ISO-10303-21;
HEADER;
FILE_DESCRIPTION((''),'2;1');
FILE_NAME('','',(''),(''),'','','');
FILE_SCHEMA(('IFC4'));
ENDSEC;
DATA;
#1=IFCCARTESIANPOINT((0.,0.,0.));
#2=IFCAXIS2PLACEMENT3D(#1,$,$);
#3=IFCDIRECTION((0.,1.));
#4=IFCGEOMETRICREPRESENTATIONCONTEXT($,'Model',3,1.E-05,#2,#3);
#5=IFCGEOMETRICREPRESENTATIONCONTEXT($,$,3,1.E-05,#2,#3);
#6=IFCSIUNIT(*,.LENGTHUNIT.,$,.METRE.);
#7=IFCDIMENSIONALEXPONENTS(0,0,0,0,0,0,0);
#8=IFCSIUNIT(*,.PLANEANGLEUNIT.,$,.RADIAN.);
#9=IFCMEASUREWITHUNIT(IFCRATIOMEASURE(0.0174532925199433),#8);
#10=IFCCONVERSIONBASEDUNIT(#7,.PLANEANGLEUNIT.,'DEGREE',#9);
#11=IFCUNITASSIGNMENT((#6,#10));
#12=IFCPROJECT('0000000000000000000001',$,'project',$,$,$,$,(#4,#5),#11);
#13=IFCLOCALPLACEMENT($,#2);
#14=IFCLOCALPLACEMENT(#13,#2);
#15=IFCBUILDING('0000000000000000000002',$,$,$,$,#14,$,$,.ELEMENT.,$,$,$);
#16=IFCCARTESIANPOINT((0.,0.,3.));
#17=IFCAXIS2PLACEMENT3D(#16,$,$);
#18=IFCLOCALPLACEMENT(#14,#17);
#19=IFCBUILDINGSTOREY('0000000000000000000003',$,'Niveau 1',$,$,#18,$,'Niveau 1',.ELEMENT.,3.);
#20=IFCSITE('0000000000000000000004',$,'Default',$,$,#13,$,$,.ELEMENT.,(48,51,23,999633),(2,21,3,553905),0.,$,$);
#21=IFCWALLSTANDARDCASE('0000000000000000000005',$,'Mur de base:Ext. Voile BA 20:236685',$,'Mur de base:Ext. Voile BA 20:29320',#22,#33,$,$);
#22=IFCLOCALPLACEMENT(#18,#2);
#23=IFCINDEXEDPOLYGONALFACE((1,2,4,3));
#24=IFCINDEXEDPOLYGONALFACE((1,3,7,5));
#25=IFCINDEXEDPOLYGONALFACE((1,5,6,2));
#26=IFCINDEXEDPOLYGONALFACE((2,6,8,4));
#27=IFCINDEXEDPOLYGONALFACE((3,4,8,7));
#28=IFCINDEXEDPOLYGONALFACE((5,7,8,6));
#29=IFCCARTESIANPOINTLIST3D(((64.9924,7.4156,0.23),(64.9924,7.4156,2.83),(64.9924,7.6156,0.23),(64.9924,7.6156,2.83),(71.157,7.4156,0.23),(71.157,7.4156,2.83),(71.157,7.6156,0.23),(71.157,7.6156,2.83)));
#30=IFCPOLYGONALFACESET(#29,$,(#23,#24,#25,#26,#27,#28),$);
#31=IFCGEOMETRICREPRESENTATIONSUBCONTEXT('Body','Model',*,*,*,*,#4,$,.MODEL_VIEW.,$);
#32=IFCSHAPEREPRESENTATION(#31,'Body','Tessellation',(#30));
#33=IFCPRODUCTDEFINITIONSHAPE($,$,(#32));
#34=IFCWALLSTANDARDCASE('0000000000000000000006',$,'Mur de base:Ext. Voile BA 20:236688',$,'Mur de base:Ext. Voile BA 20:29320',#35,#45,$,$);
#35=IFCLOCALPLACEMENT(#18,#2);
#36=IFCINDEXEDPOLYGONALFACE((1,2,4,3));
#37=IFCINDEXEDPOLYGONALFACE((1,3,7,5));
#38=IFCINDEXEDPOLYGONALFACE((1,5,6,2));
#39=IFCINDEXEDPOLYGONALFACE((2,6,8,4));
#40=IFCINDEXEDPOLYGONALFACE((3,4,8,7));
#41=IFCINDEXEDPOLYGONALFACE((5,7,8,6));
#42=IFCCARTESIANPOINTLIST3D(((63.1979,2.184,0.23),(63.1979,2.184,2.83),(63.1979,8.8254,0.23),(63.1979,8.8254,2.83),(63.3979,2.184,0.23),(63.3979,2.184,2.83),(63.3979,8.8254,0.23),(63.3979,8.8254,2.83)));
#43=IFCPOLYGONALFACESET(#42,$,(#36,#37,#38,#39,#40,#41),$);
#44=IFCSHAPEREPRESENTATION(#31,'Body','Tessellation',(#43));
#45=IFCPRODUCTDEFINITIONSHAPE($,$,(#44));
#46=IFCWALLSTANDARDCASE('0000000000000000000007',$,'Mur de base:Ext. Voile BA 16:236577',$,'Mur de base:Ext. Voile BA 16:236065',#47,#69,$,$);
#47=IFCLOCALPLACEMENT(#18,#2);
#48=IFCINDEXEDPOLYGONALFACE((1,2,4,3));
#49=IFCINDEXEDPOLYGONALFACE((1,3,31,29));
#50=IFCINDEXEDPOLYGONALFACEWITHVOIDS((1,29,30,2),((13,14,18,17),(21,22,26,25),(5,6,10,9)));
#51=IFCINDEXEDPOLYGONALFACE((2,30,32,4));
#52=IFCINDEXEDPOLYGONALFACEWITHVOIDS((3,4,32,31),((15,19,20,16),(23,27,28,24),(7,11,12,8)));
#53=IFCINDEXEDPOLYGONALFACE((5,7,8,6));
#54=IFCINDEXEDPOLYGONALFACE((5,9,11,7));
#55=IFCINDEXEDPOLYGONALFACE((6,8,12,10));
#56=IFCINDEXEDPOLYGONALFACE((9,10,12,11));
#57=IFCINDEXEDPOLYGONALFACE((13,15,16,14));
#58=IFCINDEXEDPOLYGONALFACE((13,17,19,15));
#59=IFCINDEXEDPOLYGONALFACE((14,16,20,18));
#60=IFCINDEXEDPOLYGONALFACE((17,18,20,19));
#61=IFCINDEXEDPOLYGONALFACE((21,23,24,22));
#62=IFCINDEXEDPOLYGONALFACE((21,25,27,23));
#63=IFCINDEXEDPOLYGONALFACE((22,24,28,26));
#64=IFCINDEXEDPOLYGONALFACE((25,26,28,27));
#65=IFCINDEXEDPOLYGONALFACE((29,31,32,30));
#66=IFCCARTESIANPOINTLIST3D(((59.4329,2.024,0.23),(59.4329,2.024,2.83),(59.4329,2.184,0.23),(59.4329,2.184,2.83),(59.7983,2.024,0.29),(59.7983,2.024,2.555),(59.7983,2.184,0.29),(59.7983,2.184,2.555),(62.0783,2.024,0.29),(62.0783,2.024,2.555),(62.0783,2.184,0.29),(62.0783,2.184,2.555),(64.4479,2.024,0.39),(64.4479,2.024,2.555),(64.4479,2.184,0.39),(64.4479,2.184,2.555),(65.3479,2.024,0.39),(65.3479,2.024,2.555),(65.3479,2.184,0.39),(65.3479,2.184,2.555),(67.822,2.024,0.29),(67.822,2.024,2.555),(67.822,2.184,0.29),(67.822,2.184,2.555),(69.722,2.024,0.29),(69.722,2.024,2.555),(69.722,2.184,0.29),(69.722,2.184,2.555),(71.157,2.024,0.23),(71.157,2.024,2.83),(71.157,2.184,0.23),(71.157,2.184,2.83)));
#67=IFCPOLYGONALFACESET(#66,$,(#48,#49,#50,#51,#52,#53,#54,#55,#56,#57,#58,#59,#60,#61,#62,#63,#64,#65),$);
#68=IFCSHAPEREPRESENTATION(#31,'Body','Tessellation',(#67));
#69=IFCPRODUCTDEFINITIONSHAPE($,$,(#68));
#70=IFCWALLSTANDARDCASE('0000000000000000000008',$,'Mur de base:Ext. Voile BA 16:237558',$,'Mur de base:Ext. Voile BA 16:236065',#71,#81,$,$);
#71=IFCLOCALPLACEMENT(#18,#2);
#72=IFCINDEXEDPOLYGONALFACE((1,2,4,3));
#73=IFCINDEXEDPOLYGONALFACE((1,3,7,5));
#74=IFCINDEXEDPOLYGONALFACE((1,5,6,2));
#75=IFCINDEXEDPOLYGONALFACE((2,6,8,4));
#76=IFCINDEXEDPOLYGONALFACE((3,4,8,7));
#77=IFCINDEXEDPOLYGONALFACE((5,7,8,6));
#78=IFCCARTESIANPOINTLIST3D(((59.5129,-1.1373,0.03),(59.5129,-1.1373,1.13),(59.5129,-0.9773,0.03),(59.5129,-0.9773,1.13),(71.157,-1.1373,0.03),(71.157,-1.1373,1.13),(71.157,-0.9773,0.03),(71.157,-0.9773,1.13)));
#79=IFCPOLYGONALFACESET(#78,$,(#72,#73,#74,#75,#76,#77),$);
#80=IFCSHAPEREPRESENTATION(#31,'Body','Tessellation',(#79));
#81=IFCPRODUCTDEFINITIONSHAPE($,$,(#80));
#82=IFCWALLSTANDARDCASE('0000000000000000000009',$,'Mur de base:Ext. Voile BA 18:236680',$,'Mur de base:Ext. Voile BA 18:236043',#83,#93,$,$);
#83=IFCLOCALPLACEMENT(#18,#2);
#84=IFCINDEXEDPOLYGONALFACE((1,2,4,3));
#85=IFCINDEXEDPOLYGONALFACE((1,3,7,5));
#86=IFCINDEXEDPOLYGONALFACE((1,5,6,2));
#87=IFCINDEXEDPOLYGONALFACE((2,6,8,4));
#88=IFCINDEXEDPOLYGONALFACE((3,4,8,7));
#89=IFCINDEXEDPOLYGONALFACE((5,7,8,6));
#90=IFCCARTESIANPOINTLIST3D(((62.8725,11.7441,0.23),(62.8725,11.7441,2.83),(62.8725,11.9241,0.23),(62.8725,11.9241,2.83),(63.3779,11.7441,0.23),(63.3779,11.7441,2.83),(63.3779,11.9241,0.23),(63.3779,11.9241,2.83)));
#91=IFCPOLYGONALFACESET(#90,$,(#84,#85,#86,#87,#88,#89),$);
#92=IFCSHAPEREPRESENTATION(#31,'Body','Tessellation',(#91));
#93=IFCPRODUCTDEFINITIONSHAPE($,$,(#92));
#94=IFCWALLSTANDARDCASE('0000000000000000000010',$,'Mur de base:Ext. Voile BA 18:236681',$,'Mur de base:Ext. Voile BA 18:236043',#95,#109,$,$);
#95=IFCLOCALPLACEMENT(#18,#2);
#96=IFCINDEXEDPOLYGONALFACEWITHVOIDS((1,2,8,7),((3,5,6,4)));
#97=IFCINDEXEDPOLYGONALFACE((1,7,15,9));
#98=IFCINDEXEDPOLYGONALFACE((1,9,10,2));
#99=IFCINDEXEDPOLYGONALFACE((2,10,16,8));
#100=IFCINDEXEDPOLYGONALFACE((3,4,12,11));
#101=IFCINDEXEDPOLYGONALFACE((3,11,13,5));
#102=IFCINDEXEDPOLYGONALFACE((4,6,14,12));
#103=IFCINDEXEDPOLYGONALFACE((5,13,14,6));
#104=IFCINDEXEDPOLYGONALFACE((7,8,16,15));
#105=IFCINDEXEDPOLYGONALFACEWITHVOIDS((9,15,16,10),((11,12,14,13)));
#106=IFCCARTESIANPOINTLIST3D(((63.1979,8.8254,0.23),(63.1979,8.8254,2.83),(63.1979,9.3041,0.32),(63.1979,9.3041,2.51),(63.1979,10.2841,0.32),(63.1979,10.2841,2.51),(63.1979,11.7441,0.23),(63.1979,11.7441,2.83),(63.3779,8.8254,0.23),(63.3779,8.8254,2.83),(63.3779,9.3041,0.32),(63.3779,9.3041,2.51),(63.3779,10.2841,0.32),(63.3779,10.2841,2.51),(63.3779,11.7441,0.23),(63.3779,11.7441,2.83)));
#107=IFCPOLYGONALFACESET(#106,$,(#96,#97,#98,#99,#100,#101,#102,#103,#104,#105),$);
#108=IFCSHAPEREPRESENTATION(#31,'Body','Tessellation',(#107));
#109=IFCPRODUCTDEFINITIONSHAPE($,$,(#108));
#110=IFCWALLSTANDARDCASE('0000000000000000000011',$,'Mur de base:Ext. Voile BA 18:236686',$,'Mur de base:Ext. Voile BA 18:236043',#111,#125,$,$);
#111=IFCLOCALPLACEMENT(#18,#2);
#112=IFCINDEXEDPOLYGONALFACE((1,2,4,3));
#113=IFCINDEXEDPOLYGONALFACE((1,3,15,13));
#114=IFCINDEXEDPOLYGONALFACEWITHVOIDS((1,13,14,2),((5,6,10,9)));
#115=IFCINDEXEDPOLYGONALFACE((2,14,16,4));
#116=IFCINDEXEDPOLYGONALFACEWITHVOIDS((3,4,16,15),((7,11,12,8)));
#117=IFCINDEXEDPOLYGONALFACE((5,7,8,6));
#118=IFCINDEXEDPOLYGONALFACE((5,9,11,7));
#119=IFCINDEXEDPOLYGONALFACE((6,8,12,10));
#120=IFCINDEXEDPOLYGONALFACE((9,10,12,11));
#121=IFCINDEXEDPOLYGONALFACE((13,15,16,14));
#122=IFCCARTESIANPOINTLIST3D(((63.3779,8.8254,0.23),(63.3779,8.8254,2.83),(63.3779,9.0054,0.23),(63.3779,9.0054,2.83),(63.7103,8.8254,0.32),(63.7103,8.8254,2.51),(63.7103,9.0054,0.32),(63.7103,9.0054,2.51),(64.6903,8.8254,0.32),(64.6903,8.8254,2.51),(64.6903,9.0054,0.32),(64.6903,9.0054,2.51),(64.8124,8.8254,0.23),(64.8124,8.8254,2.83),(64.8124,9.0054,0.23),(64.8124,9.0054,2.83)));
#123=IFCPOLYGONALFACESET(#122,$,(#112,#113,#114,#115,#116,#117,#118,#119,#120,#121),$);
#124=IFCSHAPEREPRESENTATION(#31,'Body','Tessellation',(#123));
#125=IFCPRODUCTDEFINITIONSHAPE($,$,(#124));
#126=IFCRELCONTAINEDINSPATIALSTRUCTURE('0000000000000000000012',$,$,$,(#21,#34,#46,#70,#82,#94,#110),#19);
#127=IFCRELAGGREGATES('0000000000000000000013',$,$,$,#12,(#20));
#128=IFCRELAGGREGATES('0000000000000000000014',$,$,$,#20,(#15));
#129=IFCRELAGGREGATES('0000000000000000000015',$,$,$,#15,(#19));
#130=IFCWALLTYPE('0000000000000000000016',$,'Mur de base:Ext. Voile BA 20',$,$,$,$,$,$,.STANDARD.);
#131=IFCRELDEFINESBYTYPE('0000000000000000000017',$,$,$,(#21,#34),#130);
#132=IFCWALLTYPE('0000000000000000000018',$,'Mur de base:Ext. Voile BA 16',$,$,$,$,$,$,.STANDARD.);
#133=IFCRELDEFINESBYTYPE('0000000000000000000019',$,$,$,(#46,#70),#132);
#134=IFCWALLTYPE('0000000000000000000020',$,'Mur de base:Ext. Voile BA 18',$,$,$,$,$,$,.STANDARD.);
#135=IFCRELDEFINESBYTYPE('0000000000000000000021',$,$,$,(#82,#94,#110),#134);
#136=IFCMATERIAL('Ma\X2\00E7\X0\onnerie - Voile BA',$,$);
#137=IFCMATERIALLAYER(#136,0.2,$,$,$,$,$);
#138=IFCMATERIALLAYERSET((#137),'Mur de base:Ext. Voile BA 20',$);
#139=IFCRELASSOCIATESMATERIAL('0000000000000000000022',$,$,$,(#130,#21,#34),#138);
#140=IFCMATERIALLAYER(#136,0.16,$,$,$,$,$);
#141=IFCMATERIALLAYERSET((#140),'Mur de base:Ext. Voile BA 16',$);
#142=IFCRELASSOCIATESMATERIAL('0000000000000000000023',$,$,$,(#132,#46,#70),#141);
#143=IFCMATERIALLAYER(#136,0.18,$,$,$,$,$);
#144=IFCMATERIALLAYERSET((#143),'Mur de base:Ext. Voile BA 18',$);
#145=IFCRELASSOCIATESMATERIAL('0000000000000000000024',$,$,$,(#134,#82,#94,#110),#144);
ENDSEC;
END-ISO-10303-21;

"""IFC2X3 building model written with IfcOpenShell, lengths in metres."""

from ifc_helpers import new_model, entity, si_unit, converted_unit, direction, frame, frame_2d, origin, origin_2d_with_axis, place, context, subcontext, project, spatial, rectangle, extrude, material, layer, layer_set, layer_usage, type_object, element, save


model = new_model("IFC2X3")

# Units and contexts
model_context = context("Model", 3, precision=1e-05, world=origin(), true_north=direction((0.0, 1.0)))
context_of_model = context(None, 3, precision=1e-05, world=origin(), true_north=direction((0.0, 1.0)))
body_context = subcontext(model_context, "Body", "Model", "MODEL_VIEW")
ifc_project = project(units=[si_unit("LENGTHUNIT", "METRE"), converted_unit("PLANEANGLEUNIT", "DEGREE", entity("IfcRatioMeasure", 0.0174532925199433), si_unit("PLANEANGLEUNIT", "RADIAN"), dimensions=[0, 0, 0, 0, 0, 0, 0])], contexts=[model_context, context_of_model])

# Site, building, storey
site_placement = place(None, origin())
site = spatial("IfcSite", under=ifc_project, at=site_placement, Name="Default", CompositionType="ELEMENT", RefLatitude=(48, 51, 23, 999633), RefLongitude=(2, 21, 3, 553905), RefElevation=0.0)
building_placement = place(site_placement, origin())
building = spatial("IfcBuilding", under=site, at=building_placement, CompositionType="ELEMENT")
storey_placement = place(building_placement, frame((0.0, 0.0, 3.0)))
storey = spatial("IfcBuildingStorey", under=building, at=storey_placement, Name="Niveau 1", LongName="Niveau 1", CompositionType="ELEMENT", Elevation=3.0)

# Walls
ifc_material = material(Name="Maçonnerie - Voile BA")
ifc_layer_1 = layer(ifc_material, 0.2)
ifc_layer_set_1 = layer_set([ifc_layer_1], Name="Mur de base:Ext. Voile BA 20")
ifc_layer_usage_1 = layer_usage(ifc_layer_set_1, "AXIS2", "NEGATIVE", 0.1)
wall_type_1 = type_object("IfcWallType", Name="Mur de base:Ext. Voile BA 20", PredefinedType="STANDARD", material=ifc_layer_set_1)
wall_1_placement = place(storey_placement, frame((64.9924, 7.5156, 0.23)))
element("IfcWallStandardCase", 1, at=wall_1_placement, inside=storey, type_object=wall_type_1, material=ifc_layer_usage_1, Name="Mur de base:Ext. Voile BA 20:236685", ObjectType="Mur de base:Ext. Voile BA 20:29320", context=body_context, shape_type="SweptSolid", body=[
    extrude(rectangle(XDim=6.1647, YDim=0.2, at=frame_2d((3.0823, 0.0), x_axis=(-1.0, 0.0))), origin(), (0.0, 0.0, 1.0), 2.6),
])
ifc_layer_usage_2 = layer_usage(ifc_layer_set_1, "AXIS2", "NEGATIVE", 0.1)
wall_2_placement = place(storey_placement, frame((63.2979, 8.8254, 0.23), z_axis=(0.0, 0.0, 1.0), x_axis=(0.0, -1.0, 0.0)))
element("IfcWallStandardCase", 2, at=wall_2_placement, inside=storey, type_object=wall_type_1, material=ifc_layer_usage_2, Name="Mur de base:Ext. Voile BA 20:236688", ObjectType="Mur de base:Ext. Voile BA 20:29320", context=body_context, shape_type="SweptSolid", body=[
    extrude(rectangle(XDim=6.6414, YDim=0.2, at=frame_2d((3.3207, 0.0), x_axis=(-1.0, 0.0))), origin(), (0.0, 0.0, 1.0), 2.6),
])

# Shared definitions
ifc_layer_2 = layer(ifc_material, 0.16)
ifc_layer_set_2 = layer_set([ifc_layer_2], Name="Mur de base:Ext. Voile BA 16")
wall_type_2 = type_object("IfcWallType", Name="Mur de base:Ext. Voile BA 16", PredefinedType="STANDARD", material=ifc_layer_set_2)

# Wall, openings
ifc_layer_usage_3 = layer_usage(ifc_layer_set_2, "AXIS2", "NEGATIVE", 0.08)
wall_3_placement = place(storey_placement, frame((71.157, 2.104, 0.23), z_axis=(0.0, 0.0, 1.0), x_axis=(-1.0, 0.0, 0.0)))
wall_3 = element("IfcWallStandardCase", 3, at=wall_3_placement, inside=storey, type_object=wall_type_2, material=ifc_layer_usage_3, Name="Mur de base:Ext. Voile BA 16:236577", ObjectType="Mur de base:Ext. Voile BA 16:236065", context=body_context, shape_type="SweptSolid", body=[
    extrude(rectangle(XDim=11.7241, YDim=0.16, at=frame_2d((5.8621, 0.0), x_axis=(-1.0, 0.0))), origin(), (0.0, 0.0, 1.0), 2.6),
])
opening_1_placement = place(wall_3_placement, origin())
element("IfcOpeningElement", 4, at=opening_1_placement, cuts=wall_3, ObjectType="Opening", context=body_context, shape_type="SweptSolid", body=[
    extrude(rectangle(XDim=2.265, YDim=2.28, at=origin_2d_with_axis()), frame((10.2187, -0.08, 1.1925), z_axis=(0.0, 1.0, 0.0), x_axis=(0.0, 0.0, -1.0)), (0.0, 0.0, 1.0), 0.16),
])
opening_2_placement = place(wall_3_placement, origin())
element("IfcOpeningElement", 5, at=opening_2_placement, cuts=wall_3, ObjectType="Opening", context=body_context, shape_type="SweptSolid", body=[
    extrude(rectangle(XDim=2.265, YDim=1.9, at=origin_2d_with_axis()), frame((2.385, -0.08, 1.1925), z_axis=(0.0, 1.0, 0.0), x_axis=(0.0, 0.0, -1.0)), (0.0, 0.0, 1.0), 0.16),
])
opening_3_placement = place(wall_3_placement, origin())
element("IfcOpeningElement", 6, at=opening_3_placement, cuts=wall_3, ObjectType="Opening", context=body_context, shape_type="SweptSolid", body=[
    extrude(rectangle(XDim=2.165, YDim=0.9, at=frame_2d((0.0, 0.0), x_axis=(1.0, 0.0))), frame((6.2591, -0.08, 1.2425), z_axis=(0.0, 1.0, 0.0), x_axis=(0.0, 0.0, -1.0)), (0.0, 0.0, 1.0), 0.16),
])

# Walls
ifc_layer_usage_4 = layer_usage(ifc_layer_set_2, "AXIS2", "POSITIVE", -0.08)
wall_4_placement = place(storey_placement, frame((71.157, -1.0573, 0.03), z_axis=(0.0, 0.0, 1.0), x_axis=(-1.0, 0.0, 0.0)))
element("IfcWallStandardCase", 7, at=wall_4_placement, inside=storey, type_object=wall_type_2, material=ifc_layer_usage_4, Name="Mur de base:Ext. Voile BA 16:237558", ObjectType="Mur de base:Ext. Voile BA 16:236065", context=body_context, shape_type="SweptSolid", body=[
    extrude(rectangle(XDim=11.6441, YDim=0.16, at=frame_2d((5.8221, 0.0), x_axis=(-1.0, 0.0))), origin(), (0.0, 0.0, 1.0), 1.1),
])
ifc_layer_3 = layer(ifc_material, 0.18)
ifc_layer_set_3 = layer_set([ifc_layer_3], Name="Mur de base:Ext. Voile BA 18")
ifc_layer_usage_5 = layer_usage(ifc_layer_set_3, "AXIS2", "NEGATIVE", 0.09)
wall_type_3 = type_object("IfcWallType", Name="Mur de base:Ext. Voile BA 18", PredefinedType="STANDARD", material=ifc_layer_set_3)
wall_5_placement = place(storey_placement, frame((62.8725, 11.8341, 0.23)))
element("IfcWallStandardCase", 8, at=wall_5_placement, inside=storey, type_object=wall_type_3, material=ifc_layer_usage_5, Name="Mur de base:Ext. Voile BA 18:236680", ObjectType="Mur de base:Ext. Voile BA 18:236043", context=body_context, shape_type="SweptSolid", body=[
    extrude(rectangle(XDim=0.5054, YDim=0.18, at=frame_2d((0.2527, 0.0), x_axis=(-1.0, 0.0))), origin(), (0.0, 0.0, 1.0), 2.6),
])

# Walls, openings
ifc_layer_usage_6 = layer_usage(ifc_layer_set_3, "AXIS2", "NEGATIVE", 0.09)
wall_6_placement = place(storey_placement, frame((63.2879, 11.7441, 0.23), z_axis=(0.0, 0.0, 1.0), x_axis=(0.0, -1.0, 0.0)))
wall_6 = element("IfcWallStandardCase", 9, at=wall_6_placement, inside=storey, type_object=wall_type_3, material=ifc_layer_usage_6, Name="Mur de base:Ext. Voile BA 18:236681", ObjectType="Mur de base:Ext. Voile BA 18:236043", context=body_context, shape_type="SweptSolid", body=[
    extrude(rectangle(XDim=2.9187, YDim=0.18, at=frame_2d((1.4593, 0.0), x_axis=(-1.0, 0.0))), origin(), (0.0, 0.0, 1.0), 2.6),
])
opening_4_placement = place(wall_6_placement, origin())
element("IfcOpeningElement", 10, at=opening_4_placement, cuts=wall_6, ObjectType="Opening", context=body_context, shape_type="SweptSolid", body=[
    extrude(rectangle(XDim=2.19, YDim=0.98, at=frame_2d((0.0, 0.0), x_axis=(1.0, 0.0))), frame((1.95, -0.09, 1.185), z_axis=(0.0, 1.0, 0.0), x_axis=(0.0, 0.0, -1.0)), (0.0, 0.0, 1.0), 0.18),
])
ifc_layer_usage_7 = layer_usage(ifc_layer_set_3, "AXIS2", "POSITIVE", -0.09)
wall_7_placement = place(storey_placement, frame((64.8124, 8.9154, 0.23), z_axis=(0.0, 0.0, 1.0), x_axis=(-1.0, 0.0, 0.0)))
wall_7 = element("IfcWallStandardCase", 11, at=wall_7_placement, inside=storey, type_object=wall_type_3, material=ifc_layer_usage_7, Name="Mur de base:Ext. Voile BA 18:236686", ObjectType="Mur de base:Ext. Voile BA 18:236043", context=body_context, shape_type="SweptSolid", body=[
    extrude(rectangle(XDim=1.4344, YDim=0.18, at=frame_2d((0.7172, 0.0), x_axis=(-1.0, 0.0))), origin(), (0.0, 0.0, 1.0), 2.6),
])
opening_5_placement = place(wall_7_placement, origin())
element("IfcOpeningElement", 12, at=opening_5_placement, cuts=wall_7, ObjectType="Opening", context=body_context, shape_type="SweptSolid", body=[
    extrude(rectangle(XDim=2.19, YDim=0.98, at=frame_2d((0.0, 0.0), x_axis=(1.0, 0.0))), frame((0.6121, -0.09, 1.185), z_axis=(0.0, 1.0, 0.0), x_axis=(0.0, 0.0, -1.0)), (0.0, 0.0, 1.0), 0.18),
])

save(model, "model.ifc")
